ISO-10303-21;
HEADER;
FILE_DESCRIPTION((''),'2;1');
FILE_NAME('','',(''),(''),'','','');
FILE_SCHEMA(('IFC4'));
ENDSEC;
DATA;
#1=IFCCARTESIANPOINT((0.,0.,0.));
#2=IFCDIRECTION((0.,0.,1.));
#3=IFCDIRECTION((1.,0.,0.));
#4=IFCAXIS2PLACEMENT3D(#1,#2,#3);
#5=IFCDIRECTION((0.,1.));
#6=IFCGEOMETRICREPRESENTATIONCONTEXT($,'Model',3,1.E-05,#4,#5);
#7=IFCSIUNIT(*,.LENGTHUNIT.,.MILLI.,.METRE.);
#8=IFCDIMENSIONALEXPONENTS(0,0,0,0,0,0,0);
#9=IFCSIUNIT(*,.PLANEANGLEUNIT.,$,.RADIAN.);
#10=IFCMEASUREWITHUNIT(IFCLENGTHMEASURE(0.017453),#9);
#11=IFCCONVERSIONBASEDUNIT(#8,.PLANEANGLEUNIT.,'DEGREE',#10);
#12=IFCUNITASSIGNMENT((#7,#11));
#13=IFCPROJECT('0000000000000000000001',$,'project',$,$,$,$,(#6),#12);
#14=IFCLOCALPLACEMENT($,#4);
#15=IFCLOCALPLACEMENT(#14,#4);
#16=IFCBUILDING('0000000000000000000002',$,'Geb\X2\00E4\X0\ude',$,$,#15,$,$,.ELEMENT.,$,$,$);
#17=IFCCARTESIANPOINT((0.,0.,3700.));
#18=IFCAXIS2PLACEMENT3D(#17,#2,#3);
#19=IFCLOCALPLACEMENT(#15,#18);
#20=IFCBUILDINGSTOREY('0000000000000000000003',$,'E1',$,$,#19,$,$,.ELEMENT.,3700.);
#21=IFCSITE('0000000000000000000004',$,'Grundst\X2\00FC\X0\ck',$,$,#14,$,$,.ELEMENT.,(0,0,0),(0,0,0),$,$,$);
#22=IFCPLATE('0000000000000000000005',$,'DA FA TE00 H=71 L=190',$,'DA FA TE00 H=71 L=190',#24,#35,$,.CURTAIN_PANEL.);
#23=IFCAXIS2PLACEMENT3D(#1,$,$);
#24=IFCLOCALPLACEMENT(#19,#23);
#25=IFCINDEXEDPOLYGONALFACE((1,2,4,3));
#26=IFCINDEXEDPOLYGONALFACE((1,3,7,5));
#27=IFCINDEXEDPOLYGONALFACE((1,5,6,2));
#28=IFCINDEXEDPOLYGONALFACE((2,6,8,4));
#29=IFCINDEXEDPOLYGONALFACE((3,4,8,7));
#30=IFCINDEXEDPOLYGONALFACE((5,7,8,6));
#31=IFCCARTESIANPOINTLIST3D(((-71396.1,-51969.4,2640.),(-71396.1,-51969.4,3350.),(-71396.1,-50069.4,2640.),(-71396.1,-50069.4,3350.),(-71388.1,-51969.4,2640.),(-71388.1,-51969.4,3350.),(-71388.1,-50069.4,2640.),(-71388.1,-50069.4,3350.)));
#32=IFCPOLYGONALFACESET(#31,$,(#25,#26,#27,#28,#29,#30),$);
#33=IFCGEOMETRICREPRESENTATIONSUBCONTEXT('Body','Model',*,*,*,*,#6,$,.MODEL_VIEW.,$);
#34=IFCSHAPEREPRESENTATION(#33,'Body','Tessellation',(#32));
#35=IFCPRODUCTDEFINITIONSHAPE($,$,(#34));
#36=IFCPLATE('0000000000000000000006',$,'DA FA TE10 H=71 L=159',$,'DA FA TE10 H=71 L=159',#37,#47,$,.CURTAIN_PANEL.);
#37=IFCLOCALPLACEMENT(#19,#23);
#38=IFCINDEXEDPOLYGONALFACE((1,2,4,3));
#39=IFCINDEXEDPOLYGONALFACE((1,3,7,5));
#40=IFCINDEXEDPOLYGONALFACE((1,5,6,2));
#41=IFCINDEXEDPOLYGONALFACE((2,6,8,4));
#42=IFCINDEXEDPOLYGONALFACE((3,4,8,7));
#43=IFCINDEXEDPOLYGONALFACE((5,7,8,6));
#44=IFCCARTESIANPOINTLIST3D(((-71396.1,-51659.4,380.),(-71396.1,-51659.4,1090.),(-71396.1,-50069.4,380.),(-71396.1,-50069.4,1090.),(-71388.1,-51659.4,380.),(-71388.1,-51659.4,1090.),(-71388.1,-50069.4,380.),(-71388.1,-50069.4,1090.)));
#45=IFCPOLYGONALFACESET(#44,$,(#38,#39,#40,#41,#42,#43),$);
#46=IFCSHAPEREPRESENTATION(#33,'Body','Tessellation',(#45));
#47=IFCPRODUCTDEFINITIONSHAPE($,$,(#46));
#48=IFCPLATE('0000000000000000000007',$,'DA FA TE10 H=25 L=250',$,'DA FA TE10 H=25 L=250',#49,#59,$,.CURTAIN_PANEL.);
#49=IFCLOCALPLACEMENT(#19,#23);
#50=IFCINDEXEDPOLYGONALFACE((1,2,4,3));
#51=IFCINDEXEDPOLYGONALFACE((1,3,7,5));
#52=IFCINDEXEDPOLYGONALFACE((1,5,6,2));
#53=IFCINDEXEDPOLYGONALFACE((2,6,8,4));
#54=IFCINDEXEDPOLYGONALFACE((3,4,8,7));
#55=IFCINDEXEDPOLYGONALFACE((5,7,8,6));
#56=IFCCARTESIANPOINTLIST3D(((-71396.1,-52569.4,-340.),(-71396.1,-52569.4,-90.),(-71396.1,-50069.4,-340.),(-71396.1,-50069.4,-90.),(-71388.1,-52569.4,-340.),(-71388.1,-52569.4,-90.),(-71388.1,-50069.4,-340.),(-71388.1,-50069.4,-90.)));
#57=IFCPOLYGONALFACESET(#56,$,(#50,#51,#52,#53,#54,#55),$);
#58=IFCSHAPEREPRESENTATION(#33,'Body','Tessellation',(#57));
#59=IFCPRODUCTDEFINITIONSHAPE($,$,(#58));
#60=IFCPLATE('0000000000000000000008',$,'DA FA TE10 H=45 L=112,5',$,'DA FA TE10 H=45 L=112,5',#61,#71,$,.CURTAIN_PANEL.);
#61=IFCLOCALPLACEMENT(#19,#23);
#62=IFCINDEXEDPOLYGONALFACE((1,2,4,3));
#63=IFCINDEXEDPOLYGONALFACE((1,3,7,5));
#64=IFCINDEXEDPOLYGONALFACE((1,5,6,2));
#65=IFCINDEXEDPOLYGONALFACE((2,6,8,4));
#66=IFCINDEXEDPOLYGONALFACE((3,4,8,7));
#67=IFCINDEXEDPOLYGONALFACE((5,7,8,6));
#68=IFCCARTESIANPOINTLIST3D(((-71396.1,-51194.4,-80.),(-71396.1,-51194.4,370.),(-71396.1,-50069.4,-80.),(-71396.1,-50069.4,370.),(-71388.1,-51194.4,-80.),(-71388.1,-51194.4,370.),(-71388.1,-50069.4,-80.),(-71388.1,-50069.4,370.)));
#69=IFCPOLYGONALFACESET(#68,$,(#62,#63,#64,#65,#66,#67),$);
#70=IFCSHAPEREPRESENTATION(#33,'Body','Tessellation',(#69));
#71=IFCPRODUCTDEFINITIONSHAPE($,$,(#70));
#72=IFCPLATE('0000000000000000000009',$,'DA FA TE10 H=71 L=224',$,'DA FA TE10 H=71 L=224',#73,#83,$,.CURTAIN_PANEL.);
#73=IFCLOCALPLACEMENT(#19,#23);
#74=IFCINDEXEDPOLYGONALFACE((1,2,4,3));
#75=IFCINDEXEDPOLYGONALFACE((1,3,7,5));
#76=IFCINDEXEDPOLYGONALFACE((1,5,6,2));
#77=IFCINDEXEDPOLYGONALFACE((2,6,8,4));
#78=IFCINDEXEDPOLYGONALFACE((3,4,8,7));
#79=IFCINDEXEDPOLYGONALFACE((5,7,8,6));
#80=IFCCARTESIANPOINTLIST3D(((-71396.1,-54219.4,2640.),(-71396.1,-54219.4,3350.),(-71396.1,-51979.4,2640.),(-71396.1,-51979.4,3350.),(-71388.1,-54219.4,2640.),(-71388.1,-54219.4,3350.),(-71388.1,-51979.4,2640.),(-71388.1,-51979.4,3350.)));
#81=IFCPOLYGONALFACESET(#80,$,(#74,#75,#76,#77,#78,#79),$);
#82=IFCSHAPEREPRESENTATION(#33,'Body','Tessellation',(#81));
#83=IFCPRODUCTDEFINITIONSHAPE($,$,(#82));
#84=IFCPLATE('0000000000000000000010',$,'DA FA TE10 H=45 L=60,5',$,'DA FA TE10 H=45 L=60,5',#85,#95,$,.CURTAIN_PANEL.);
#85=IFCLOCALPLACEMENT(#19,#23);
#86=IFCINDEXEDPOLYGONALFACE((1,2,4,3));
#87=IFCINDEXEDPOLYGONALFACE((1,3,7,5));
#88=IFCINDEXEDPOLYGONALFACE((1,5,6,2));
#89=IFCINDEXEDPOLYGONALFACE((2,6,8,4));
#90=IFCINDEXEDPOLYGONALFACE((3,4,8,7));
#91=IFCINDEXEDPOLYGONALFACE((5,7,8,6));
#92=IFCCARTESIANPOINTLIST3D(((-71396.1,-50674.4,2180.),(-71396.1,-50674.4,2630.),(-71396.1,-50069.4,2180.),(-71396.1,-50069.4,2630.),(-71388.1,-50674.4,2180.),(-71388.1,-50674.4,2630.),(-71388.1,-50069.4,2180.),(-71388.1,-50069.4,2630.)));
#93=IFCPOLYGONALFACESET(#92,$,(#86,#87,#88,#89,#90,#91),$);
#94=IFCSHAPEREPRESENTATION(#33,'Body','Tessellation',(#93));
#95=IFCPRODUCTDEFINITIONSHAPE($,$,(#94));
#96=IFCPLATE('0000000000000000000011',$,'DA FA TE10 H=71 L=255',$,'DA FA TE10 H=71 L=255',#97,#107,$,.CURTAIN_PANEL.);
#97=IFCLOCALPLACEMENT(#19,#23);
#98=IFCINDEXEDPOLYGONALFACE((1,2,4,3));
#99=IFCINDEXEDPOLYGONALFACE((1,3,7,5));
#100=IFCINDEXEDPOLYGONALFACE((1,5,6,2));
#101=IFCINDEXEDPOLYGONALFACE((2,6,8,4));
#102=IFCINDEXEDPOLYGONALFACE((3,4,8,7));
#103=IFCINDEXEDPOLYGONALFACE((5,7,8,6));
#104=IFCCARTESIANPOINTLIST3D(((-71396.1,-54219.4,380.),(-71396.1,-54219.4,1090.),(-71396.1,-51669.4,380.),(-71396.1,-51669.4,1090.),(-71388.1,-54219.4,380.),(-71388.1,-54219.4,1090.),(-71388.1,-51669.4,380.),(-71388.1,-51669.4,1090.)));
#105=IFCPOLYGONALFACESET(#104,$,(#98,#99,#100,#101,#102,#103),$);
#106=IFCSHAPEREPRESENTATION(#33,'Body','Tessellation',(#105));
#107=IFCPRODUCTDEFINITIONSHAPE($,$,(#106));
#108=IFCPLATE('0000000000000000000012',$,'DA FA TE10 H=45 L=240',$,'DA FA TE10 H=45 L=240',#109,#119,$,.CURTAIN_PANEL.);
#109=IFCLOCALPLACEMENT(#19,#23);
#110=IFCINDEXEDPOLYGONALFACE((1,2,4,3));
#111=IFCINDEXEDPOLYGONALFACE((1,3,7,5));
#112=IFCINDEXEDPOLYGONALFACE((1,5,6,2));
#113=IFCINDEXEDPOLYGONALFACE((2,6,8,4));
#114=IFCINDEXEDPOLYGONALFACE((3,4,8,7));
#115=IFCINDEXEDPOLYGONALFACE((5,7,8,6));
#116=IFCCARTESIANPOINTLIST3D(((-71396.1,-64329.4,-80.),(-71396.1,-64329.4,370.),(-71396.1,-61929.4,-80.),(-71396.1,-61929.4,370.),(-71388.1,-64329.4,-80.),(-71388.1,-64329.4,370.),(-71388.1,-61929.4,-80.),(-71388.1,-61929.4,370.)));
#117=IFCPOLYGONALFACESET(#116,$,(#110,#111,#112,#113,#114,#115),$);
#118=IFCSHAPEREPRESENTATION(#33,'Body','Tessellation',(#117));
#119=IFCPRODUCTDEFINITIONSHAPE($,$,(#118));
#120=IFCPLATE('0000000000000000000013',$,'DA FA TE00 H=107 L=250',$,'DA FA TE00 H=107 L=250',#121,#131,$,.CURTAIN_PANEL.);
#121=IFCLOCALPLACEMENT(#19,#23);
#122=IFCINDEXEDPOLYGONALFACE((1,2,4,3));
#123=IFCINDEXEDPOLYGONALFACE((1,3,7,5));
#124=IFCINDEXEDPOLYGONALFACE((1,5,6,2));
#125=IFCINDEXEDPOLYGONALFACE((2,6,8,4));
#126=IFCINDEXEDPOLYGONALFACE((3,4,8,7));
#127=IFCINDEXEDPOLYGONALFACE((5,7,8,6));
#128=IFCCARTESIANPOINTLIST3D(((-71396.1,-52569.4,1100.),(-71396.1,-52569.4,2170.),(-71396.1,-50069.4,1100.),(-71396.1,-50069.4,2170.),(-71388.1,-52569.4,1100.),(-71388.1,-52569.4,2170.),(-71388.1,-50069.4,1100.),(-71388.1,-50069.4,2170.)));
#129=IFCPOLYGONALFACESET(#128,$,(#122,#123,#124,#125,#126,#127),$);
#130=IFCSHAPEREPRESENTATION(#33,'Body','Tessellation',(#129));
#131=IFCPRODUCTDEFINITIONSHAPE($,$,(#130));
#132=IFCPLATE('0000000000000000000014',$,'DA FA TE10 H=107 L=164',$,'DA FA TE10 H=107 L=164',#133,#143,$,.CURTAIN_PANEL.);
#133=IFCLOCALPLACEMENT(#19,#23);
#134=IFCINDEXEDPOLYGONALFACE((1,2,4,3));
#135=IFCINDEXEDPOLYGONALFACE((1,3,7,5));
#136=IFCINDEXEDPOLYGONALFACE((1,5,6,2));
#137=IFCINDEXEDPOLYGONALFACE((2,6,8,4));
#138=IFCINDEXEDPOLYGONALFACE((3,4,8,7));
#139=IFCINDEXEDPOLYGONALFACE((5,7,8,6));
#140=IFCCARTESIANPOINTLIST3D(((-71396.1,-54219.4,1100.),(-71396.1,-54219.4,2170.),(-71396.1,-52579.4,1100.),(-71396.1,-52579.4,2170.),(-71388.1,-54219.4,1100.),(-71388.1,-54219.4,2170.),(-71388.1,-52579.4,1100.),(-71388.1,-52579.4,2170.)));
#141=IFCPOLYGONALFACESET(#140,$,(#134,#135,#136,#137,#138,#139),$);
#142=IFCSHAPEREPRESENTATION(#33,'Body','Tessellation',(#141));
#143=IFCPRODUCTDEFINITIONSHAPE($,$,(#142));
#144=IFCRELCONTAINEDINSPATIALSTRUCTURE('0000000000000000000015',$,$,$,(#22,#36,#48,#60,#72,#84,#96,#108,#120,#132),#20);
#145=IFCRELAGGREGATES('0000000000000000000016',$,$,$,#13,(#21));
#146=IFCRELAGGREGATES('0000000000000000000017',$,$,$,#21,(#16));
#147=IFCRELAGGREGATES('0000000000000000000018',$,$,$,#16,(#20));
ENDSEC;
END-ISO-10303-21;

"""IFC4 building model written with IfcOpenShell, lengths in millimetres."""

from ifc_helpers import new_model, entity, si_unit, converted_unit, direction, frame, origin_with_axes, place, context, subcontext, project, spatial, line, indexed_curve, outline, extrude, source, transform, mapped, element, save


model = new_model("IFC4")

# Units and contexts
model_context = context("Model", 3, precision=1e-05, world=origin_with_axes(), true_north=direction((0.0, 1.0)))
body_context = subcontext(model_context, "Body", "Model", "MODEL_VIEW")
ifc_project = project(units=[si_unit("LENGTHUNIT", "METRE", prefix="MILLI"), converted_unit("PLANEANGLEUNIT", "DEGREE", entity("IfcLengthMeasure", 0.017453), si_unit("PLANEANGLEUNIT", "RADIAN"), dimensions=[0, 0, 0, 0, 0, 0, 0])], contexts=[model_context])

# Site, building, storey
site_placement = place(None, origin_with_axes())
site = spatial("IfcSite", under=ifc_project, at=site_placement, Name="Grundstück", CompositionType="ELEMENT", RefLatitude=(0, 0, 0), RefLongitude=(0, 0, 0))
building_placement = place(site_placement, origin_with_axes())
building = spatial("IfcBuilding", under=site, at=building_placement, Name="Gebäude", CompositionType="ELEMENT")
storey_placement = place(building_placement, frame((0.0, 0.0, 3700.0), z_axis=(0.0, 0.0, 1.0), x_axis=(1.0, 0.0, 0.0)))
storey = spatial("IfcBuildingStorey", under=building, at=storey_placement, Name="E1", CompositionType="ELEMENT", Elevation=3700.0)

# Plates
shared_shape_1 = source(origin_with_axes(), body_context, "Body", "SweptSolid", [
    extrude(outline(indexed_curve([(-950.0, 0.0), (950.0, 0.0), (950.0, 8.0), (-950.0, 8.0)], segments=[line(1, 2), line(2, 3), line(3, 4), line(4, 1)])), frame((0.0, 0.0, 710.0), z_axis=(0.0, 0.0, 1.0), x_axis=(1.0, 0.0, 0.0)), (0.0, 0.0, -1.0), 710.0),
])
plate_1_placement = place(storey_placement, frame((-71396.1, -51019.4, 2640.0), z_axis=(0.0, 0.0, 1.0), x_axis=(0.0, -1.0, 0.0)))
element("IfcPlate", 1, at=plate_1_placement, inside=storey, Name="DA FA TE00 H=71 L=190", ObjectType="DA FA TE00 H=71 L=190", PredefinedType="CURTAIN_PANEL", context=body_context, shape_type="MappedRepresentation", body=[
    mapped(shared_shape_1, transform((0.0, 0.0, 0.0), x_axis=(1.0, 0.0, 0.0), y_axis=(0.0, 1.0, 0.0), z_axis=(0.0, 0.0, 1.0), scale=1.0)),
])
shared_shape_2 = source(origin_with_axes(), body_context, "Body", "SweptSolid", [
    extrude(outline(indexed_curve([(-795.0, 0.0), (795.0, 0.0), (795.0, 8.0), (-795.0, 8.0)], segments=[line(1, 2), line(2, 3), line(3, 4), line(4, 1)])), frame((0.0, 0.0, 710.0), z_axis=(0.0, 0.0, 1.0), x_axis=(1.0, 0.0, 0.0)), (0.0, 0.0, -1.0), 710.0),
])
plate_2_placement = place(storey_placement, frame((-71396.1, -50864.4, 380.0), z_axis=(0.0, 0.0, 1.0), x_axis=(0.0, -1.0, 0.0)))
element("IfcPlate", 2, at=plate_2_placement, inside=storey, Name="DA FA TE10 H=71 L=159", ObjectType="DA FA TE10 H=71 L=159", PredefinedType="CURTAIN_PANEL", context=body_context, shape_type="MappedRepresentation", body=[
    mapped(shared_shape_2, transform((0.0, 0.0, 0.0), x_axis=(1.0, 0.0, 0.0), y_axis=(0.0, 1.0, 0.0), z_axis=(0.0, 0.0, 1.0), scale=1.0)),
])
shared_shape_3 = source(origin_with_axes(), body_context, "Body", "SweptSolid", [
    extrude(outline(indexed_curve([(-1250.0, 0.0), (1250.0, 0.0), (1250.0, 8.0), (-1250.0, 8.0)], segments=[line(1, 2), line(2, 3), line(3, 4), line(4, 1)])), frame((0.0, 0.0, 250.0), z_axis=(0.0, 0.0, 1.0), x_axis=(1.0, 0.0, 0.0)), (0.0, 0.0, -1.0), 250.0),
])
plate_3_placement = place(storey_placement, frame((-71396.1, -51319.4, -340.0), z_axis=(0.0, 0.0, 1.0), x_axis=(0.0, -1.0, 0.0)))
element("IfcPlate", 3, at=plate_3_placement, inside=storey, Name="DA FA TE10 H=25 L=250", ObjectType="DA FA TE10 H=25 L=250", PredefinedType="CURTAIN_PANEL", context=body_context, shape_type="MappedRepresentation", body=[
    mapped(shared_shape_3, transform((0.0, 0.0, 0.0), x_axis=(1.0, 0.0, 0.0), y_axis=(0.0, 1.0, 0.0), z_axis=(0.0, 0.0, 1.0), scale=1.0)),
])
shared_shape_4 = source(origin_with_axes(), body_context, "Body", "SweptSolid", [
    extrude(outline(indexed_curve([(-562.5, 0.0), (562.5, 0.0), (562.5, 8.0), (-562.5, 8.0)], segments=[line(1, 2), line(2, 3), line(3, 4), line(4, 1)])), frame((0.0, 0.0, 450.0), z_axis=(0.0, 0.0, 1.0), x_axis=(1.0, 0.0, 0.0)), (0.0, 0.0, -1.0), 450.0),
])
plate_4_placement = place(storey_placement, frame((-71396.1, -50631.9, -80.0), z_axis=(0.0, 0.0, 1.0), x_axis=(0.0, -1.0, 0.0)))
element("IfcPlate", 4, at=plate_4_placement, inside=storey, Name="DA FA TE10 H=45 L=112,5", ObjectType="DA FA TE10 H=45 L=112,5", PredefinedType="CURTAIN_PANEL", context=body_context, shape_type="MappedRepresentation", body=[
    mapped(shared_shape_4, transform((0.0, 0.0, 0.0), x_axis=(1.0, 0.0, 0.0), y_axis=(0.0, 1.0, 0.0), z_axis=(0.0, 0.0, 1.0), scale=1.0)),
])
shared_shape_5 = source(origin_with_axes(), body_context, "Body", "SweptSolid", [
    extrude(outline(indexed_curve([(-1120.0, 0.0), (1120.0, 0.0), (1120.0, 8.0), (-1120.0, 8.0)], segments=[line(1, 2), line(2, 3), line(3, 4), line(4, 1)])), frame((0.0, 0.0, 710.0), z_axis=(0.0, 0.0, 1.0), x_axis=(1.0, 0.0, 0.0)), (0.0, 0.0, -1.0), 710.0),
])
plate_5_placement = place(storey_placement, frame((-71396.1, -53099.4, 2640.0), z_axis=(0.0, 0.0, 1.0), x_axis=(0.0, -1.0, 0.0)))
element("IfcPlate", 5, at=plate_5_placement, inside=storey, Name="DA FA TE10 H=71 L=224", ObjectType="DA FA TE10 H=71 L=224", PredefinedType="CURTAIN_PANEL", context=body_context, shape_type="MappedRepresentation", body=[
    mapped(shared_shape_5, transform((0.0, 0.0, 0.0), x_axis=(1.0, 0.0, 0.0), y_axis=(0.0, 1.0, 0.0), z_axis=(0.0, 0.0, 1.0), scale=1.0)),
])
shared_shape_6 = source(origin_with_axes(), body_context, "Body", "SweptSolid", [
    extrude(outline(indexed_curve([(-302.5, 0.0), (302.5, 0.0), (302.5, 8.0), (-302.5, 8.0)], segments=[line(1, 2), line(2, 3), line(3, 4), line(4, 1)])), frame((0.0, 0.0, 450.0), z_axis=(0.0, 0.0, 1.0), x_axis=(1.0, 0.0, 0.0)), (0.0, 0.0, -1.0), 450.0),
])
plate_6_placement = place(storey_placement, frame((-71396.1, -50371.9, 2180.0), z_axis=(0.0, 0.0, 1.0), x_axis=(0.0, -1.0, 0.0)))
element("IfcPlate", 6, at=plate_6_placement, inside=storey, Name="DA FA TE10 H=45 L=60,5", ObjectType="DA FA TE10 H=45 L=60,5", PredefinedType="CURTAIN_PANEL", context=body_context, shape_type="MappedRepresentation", body=[
    mapped(shared_shape_6, transform((0.0, 0.0, 0.0), x_axis=(1.0, 0.0, 0.0), y_axis=(0.0, 1.0, 0.0), z_axis=(0.0, 0.0, 1.0), scale=1.0)),
])
shared_shape_7 = source(origin_with_axes(), body_context, "Body", "SweptSolid", [
    extrude(outline(indexed_curve([(-1275.0, 0.0), (1275.0, 0.0), (1275.0, 8.0), (-1275.0, 8.0)], segments=[line(1, 2), line(2, 3), line(3, 4), line(4, 1)])), frame((0.0, 0.0, 710.0), z_axis=(0.0, 0.0, 1.0), x_axis=(1.0, 0.0, 0.0)), (0.0, 0.0, -1.0), 710.0),
])
plate_7_placement = place(storey_placement, frame((-71396.1, -52944.4, 380.0), z_axis=(0.0, 0.0, 1.0), x_axis=(0.0, -1.0, 0.0)))
element("IfcPlate", 7, at=plate_7_placement, inside=storey, Name="DA FA TE10 H=71 L=255", ObjectType="DA FA TE10 H=71 L=255", PredefinedType="CURTAIN_PANEL", context=body_context, shape_type="MappedRepresentation", body=[
    mapped(shared_shape_7, transform((0.0, 0.0, 0.0), x_axis=(1.0, 0.0, 0.0), y_axis=(0.0, 1.0, 0.0), z_axis=(0.0, 0.0, 1.0), scale=1.0)),
])
plate_8_placement = place(storey_placement, frame((-71396.1, -63129.4, -80.0), z_axis=(0.0, 0.0, 1.0), x_axis=(0.0, -1.0, 0.0)))
element("IfcPlate", 8, at=plate_8_placement, inside=storey, Name="DA FA TE10 H=45 L=240", ObjectType="DA FA TE10 H=45 L=240", PredefinedType="CURTAIN_PANEL", context=body_context, shape_type="SweptSolid", body=[
    extrude(outline(indexed_curve([(-1200.0, 0.0), (1200.0, 0.0), (1200.0, 8.0), (-1200.0, 8.0)], segments=[line(1, 2), line(2, 3), line(3, 4), line(4, 1)])), frame((0.0, 0.0, 450.0), z_axis=(0.0, 0.0, 1.0), x_axis=(1.0, 0.0, 0.0)), (0.0, 0.0, -1.0), 450.0),
])
plate_9_placement = place(storey_placement, frame((-71396.1, -51319.4, 1100.0), z_axis=(0.0, 0.0, 1.0), x_axis=(0.0, -1.0, 0.0)))
element("IfcPlate", 9, at=plate_9_placement, inside=storey, Name="DA FA TE00 H=107 L=250", ObjectType="DA FA TE00 H=107 L=250", PredefinedType="CURTAIN_PANEL", context=body_context, shape_type="SweptSolid", body=[
    extrude(outline(indexed_curve([(-1250.0, 0.0), (1250.0, 0.0), (1250.0, 8.0), (-1250.0, 8.0)], segments=[line(1, 2), line(2, 3), line(3, 4), line(4, 1)])), frame((0.0, 0.0, 1070.0), z_axis=(0.0, 0.0, 1.0), x_axis=(1.0, 0.0, 0.0)), (0.0, 0.0, -1.0), 1070.0),
])
plate_10_placement = place(storey_placement, frame((-71396.1, -53399.4, 1100.0), z_axis=(0.0, 0.0, 1.0), x_axis=(0.0, -1.0, 0.0)))
element("IfcPlate", 10, at=plate_10_placement, inside=storey, Name="DA FA TE10 H=107 L=164", ObjectType="DA FA TE10 H=107 L=164", PredefinedType="CURTAIN_PANEL", context=body_context, shape_type="SweptSolid", body=[
    extrude(outline(indexed_curve([(-820.0, 0.0), (820.0, 0.0), (820.0, 8.0), (-820.0, 8.0)], segments=[line(1, 2), line(2, 3), line(3, 4), line(4, 1)])), frame((0.0, 0.0, 1070.0), z_axis=(0.0, 0.0, 1.0), x_axis=(1.0, 0.0, 0.0)), (0.0, 0.0, -1.0), 1070.0),
])

save(model, "model.ifc")
